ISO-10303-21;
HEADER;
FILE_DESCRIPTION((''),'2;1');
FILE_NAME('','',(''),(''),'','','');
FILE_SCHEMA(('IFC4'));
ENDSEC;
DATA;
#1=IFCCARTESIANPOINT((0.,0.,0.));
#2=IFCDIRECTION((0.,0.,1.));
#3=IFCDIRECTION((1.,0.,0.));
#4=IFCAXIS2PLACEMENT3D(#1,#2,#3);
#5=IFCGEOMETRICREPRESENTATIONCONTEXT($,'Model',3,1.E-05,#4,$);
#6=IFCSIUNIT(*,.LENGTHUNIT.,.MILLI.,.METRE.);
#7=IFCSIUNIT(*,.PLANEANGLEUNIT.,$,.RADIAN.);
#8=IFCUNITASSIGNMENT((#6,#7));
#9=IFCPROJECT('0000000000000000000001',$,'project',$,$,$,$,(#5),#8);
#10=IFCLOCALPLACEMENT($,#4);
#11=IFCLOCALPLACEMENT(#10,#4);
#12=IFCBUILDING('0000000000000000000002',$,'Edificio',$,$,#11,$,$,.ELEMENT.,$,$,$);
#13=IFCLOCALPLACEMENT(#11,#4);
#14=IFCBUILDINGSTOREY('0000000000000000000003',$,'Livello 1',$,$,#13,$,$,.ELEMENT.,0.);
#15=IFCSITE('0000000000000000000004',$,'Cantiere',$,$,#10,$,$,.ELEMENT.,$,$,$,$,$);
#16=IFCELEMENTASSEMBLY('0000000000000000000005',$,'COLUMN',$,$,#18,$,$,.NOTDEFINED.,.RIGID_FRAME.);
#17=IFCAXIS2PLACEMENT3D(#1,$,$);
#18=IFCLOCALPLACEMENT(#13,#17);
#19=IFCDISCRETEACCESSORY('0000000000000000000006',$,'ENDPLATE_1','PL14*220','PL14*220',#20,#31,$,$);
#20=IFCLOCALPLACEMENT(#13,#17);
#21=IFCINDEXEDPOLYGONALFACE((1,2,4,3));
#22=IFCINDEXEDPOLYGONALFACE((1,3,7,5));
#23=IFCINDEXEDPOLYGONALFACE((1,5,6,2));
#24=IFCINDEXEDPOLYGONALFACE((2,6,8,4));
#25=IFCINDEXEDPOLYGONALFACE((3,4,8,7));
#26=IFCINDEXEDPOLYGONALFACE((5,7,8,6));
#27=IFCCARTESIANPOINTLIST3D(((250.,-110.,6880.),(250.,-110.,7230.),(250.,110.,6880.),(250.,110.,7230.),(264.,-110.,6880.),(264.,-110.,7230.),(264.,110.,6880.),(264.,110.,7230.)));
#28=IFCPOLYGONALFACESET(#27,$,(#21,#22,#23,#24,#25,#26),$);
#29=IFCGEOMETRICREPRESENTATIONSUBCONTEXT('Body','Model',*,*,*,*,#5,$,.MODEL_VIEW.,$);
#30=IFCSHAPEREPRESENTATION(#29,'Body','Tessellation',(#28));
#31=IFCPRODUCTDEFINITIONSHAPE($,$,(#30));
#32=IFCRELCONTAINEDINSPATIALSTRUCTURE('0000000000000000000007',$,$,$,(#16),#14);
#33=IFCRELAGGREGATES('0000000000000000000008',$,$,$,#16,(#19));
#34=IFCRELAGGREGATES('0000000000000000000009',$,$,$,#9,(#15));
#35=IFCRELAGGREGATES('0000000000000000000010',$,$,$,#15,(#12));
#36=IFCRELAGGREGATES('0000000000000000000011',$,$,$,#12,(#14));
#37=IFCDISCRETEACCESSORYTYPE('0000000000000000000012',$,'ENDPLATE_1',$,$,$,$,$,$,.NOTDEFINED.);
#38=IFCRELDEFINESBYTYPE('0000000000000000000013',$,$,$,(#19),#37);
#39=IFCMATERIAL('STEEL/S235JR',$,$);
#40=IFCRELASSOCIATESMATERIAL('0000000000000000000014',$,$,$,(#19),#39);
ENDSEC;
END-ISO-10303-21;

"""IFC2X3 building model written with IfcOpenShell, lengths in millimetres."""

from ifc_helpers import new_model, si_unit, frame, origin_with_axes, place, context, subcontext, project, spatial, polyline, outline, extrude, material, type_object, element, aggregate, save


model = new_model("IFC2X3")

# Units and contexts
model_context = context("Model", 3, precision=1e-05, world=origin_with_axes())
body_context = subcontext(model_context, "Body", "Model", "MODEL_VIEW")
ifc_project = project(units=[si_unit("LENGTHUNIT", "METRE", prefix="MILLI"), si_unit("PLANEANGLEUNIT", "RADIAN")], contexts=[model_context])

# Site, building, storey
site_placement = place(None, origin_with_axes())
site = spatial("IfcSite", under=ifc_project, at=site_placement, Name="Cantiere", CompositionType="ELEMENT")
building_placement = place(site_placement, origin_with_axes())
building = spatial("IfcBuilding", under=site, at=building_placement, Name="Edificio", CompositionType="ELEMENT")
storey_placement = place(building_placement, origin_with_axes())
storey = spatial("IfcBuildingStorey", under=building, at=storey_placement, Name="Livello 1", CompositionType="ELEMENT", Elevation=0.0)

# Element assembly
ifc_material = material(Name="STEEL/S235JR")
assembly_1_placement = place(storey_placement, origin_with_axes())
assembly_1 = element("IfcElementAssembly", 1, at=assembly_1_placement, inside=storey, Name="COLUMN", AssemblyPlace="NOTDEFINED", PredefinedType="RIGID_FRAME")

# Discrete accessory
discrete_accessory_type_1 = type_object("IfcDiscreteAccessoryType", Name="ENDPLATE_1")
discrete_accessory_1_placement = place(assembly_1_placement, frame((257.0, 110.0, 6880.0), z_axis=(1.0, 0.0, 0.0), x_axis=(0.0, 0.0, 1.0)))
discrete_accessory_1 = element("IfcDiscreteAccessory", 2, at=discrete_accessory_1_placement, type_object=discrete_accessory_type_1, material=ifc_material, Name="ENDPLATE_1", Description="PL14*220", ObjectType="PL14*220", context=body_context, shape_type="SweptSolid", body=[
    extrude(outline(polyline([(0.0, 0.0), (350.0, 0.0), (350.0, 220.0), (0.0, 220.0), (0.0, 0.0)])), frame((0.0, 0.0, -7.0), z_axis=(0.0, 0.0, 1.0), x_axis=(1.0, 0.0, 0.0)), (0.0, 0.0, 1.0), 14.0),
])
aggregate(assembly_1, [discrete_accessory_1])

save(model, "model.ifc")
